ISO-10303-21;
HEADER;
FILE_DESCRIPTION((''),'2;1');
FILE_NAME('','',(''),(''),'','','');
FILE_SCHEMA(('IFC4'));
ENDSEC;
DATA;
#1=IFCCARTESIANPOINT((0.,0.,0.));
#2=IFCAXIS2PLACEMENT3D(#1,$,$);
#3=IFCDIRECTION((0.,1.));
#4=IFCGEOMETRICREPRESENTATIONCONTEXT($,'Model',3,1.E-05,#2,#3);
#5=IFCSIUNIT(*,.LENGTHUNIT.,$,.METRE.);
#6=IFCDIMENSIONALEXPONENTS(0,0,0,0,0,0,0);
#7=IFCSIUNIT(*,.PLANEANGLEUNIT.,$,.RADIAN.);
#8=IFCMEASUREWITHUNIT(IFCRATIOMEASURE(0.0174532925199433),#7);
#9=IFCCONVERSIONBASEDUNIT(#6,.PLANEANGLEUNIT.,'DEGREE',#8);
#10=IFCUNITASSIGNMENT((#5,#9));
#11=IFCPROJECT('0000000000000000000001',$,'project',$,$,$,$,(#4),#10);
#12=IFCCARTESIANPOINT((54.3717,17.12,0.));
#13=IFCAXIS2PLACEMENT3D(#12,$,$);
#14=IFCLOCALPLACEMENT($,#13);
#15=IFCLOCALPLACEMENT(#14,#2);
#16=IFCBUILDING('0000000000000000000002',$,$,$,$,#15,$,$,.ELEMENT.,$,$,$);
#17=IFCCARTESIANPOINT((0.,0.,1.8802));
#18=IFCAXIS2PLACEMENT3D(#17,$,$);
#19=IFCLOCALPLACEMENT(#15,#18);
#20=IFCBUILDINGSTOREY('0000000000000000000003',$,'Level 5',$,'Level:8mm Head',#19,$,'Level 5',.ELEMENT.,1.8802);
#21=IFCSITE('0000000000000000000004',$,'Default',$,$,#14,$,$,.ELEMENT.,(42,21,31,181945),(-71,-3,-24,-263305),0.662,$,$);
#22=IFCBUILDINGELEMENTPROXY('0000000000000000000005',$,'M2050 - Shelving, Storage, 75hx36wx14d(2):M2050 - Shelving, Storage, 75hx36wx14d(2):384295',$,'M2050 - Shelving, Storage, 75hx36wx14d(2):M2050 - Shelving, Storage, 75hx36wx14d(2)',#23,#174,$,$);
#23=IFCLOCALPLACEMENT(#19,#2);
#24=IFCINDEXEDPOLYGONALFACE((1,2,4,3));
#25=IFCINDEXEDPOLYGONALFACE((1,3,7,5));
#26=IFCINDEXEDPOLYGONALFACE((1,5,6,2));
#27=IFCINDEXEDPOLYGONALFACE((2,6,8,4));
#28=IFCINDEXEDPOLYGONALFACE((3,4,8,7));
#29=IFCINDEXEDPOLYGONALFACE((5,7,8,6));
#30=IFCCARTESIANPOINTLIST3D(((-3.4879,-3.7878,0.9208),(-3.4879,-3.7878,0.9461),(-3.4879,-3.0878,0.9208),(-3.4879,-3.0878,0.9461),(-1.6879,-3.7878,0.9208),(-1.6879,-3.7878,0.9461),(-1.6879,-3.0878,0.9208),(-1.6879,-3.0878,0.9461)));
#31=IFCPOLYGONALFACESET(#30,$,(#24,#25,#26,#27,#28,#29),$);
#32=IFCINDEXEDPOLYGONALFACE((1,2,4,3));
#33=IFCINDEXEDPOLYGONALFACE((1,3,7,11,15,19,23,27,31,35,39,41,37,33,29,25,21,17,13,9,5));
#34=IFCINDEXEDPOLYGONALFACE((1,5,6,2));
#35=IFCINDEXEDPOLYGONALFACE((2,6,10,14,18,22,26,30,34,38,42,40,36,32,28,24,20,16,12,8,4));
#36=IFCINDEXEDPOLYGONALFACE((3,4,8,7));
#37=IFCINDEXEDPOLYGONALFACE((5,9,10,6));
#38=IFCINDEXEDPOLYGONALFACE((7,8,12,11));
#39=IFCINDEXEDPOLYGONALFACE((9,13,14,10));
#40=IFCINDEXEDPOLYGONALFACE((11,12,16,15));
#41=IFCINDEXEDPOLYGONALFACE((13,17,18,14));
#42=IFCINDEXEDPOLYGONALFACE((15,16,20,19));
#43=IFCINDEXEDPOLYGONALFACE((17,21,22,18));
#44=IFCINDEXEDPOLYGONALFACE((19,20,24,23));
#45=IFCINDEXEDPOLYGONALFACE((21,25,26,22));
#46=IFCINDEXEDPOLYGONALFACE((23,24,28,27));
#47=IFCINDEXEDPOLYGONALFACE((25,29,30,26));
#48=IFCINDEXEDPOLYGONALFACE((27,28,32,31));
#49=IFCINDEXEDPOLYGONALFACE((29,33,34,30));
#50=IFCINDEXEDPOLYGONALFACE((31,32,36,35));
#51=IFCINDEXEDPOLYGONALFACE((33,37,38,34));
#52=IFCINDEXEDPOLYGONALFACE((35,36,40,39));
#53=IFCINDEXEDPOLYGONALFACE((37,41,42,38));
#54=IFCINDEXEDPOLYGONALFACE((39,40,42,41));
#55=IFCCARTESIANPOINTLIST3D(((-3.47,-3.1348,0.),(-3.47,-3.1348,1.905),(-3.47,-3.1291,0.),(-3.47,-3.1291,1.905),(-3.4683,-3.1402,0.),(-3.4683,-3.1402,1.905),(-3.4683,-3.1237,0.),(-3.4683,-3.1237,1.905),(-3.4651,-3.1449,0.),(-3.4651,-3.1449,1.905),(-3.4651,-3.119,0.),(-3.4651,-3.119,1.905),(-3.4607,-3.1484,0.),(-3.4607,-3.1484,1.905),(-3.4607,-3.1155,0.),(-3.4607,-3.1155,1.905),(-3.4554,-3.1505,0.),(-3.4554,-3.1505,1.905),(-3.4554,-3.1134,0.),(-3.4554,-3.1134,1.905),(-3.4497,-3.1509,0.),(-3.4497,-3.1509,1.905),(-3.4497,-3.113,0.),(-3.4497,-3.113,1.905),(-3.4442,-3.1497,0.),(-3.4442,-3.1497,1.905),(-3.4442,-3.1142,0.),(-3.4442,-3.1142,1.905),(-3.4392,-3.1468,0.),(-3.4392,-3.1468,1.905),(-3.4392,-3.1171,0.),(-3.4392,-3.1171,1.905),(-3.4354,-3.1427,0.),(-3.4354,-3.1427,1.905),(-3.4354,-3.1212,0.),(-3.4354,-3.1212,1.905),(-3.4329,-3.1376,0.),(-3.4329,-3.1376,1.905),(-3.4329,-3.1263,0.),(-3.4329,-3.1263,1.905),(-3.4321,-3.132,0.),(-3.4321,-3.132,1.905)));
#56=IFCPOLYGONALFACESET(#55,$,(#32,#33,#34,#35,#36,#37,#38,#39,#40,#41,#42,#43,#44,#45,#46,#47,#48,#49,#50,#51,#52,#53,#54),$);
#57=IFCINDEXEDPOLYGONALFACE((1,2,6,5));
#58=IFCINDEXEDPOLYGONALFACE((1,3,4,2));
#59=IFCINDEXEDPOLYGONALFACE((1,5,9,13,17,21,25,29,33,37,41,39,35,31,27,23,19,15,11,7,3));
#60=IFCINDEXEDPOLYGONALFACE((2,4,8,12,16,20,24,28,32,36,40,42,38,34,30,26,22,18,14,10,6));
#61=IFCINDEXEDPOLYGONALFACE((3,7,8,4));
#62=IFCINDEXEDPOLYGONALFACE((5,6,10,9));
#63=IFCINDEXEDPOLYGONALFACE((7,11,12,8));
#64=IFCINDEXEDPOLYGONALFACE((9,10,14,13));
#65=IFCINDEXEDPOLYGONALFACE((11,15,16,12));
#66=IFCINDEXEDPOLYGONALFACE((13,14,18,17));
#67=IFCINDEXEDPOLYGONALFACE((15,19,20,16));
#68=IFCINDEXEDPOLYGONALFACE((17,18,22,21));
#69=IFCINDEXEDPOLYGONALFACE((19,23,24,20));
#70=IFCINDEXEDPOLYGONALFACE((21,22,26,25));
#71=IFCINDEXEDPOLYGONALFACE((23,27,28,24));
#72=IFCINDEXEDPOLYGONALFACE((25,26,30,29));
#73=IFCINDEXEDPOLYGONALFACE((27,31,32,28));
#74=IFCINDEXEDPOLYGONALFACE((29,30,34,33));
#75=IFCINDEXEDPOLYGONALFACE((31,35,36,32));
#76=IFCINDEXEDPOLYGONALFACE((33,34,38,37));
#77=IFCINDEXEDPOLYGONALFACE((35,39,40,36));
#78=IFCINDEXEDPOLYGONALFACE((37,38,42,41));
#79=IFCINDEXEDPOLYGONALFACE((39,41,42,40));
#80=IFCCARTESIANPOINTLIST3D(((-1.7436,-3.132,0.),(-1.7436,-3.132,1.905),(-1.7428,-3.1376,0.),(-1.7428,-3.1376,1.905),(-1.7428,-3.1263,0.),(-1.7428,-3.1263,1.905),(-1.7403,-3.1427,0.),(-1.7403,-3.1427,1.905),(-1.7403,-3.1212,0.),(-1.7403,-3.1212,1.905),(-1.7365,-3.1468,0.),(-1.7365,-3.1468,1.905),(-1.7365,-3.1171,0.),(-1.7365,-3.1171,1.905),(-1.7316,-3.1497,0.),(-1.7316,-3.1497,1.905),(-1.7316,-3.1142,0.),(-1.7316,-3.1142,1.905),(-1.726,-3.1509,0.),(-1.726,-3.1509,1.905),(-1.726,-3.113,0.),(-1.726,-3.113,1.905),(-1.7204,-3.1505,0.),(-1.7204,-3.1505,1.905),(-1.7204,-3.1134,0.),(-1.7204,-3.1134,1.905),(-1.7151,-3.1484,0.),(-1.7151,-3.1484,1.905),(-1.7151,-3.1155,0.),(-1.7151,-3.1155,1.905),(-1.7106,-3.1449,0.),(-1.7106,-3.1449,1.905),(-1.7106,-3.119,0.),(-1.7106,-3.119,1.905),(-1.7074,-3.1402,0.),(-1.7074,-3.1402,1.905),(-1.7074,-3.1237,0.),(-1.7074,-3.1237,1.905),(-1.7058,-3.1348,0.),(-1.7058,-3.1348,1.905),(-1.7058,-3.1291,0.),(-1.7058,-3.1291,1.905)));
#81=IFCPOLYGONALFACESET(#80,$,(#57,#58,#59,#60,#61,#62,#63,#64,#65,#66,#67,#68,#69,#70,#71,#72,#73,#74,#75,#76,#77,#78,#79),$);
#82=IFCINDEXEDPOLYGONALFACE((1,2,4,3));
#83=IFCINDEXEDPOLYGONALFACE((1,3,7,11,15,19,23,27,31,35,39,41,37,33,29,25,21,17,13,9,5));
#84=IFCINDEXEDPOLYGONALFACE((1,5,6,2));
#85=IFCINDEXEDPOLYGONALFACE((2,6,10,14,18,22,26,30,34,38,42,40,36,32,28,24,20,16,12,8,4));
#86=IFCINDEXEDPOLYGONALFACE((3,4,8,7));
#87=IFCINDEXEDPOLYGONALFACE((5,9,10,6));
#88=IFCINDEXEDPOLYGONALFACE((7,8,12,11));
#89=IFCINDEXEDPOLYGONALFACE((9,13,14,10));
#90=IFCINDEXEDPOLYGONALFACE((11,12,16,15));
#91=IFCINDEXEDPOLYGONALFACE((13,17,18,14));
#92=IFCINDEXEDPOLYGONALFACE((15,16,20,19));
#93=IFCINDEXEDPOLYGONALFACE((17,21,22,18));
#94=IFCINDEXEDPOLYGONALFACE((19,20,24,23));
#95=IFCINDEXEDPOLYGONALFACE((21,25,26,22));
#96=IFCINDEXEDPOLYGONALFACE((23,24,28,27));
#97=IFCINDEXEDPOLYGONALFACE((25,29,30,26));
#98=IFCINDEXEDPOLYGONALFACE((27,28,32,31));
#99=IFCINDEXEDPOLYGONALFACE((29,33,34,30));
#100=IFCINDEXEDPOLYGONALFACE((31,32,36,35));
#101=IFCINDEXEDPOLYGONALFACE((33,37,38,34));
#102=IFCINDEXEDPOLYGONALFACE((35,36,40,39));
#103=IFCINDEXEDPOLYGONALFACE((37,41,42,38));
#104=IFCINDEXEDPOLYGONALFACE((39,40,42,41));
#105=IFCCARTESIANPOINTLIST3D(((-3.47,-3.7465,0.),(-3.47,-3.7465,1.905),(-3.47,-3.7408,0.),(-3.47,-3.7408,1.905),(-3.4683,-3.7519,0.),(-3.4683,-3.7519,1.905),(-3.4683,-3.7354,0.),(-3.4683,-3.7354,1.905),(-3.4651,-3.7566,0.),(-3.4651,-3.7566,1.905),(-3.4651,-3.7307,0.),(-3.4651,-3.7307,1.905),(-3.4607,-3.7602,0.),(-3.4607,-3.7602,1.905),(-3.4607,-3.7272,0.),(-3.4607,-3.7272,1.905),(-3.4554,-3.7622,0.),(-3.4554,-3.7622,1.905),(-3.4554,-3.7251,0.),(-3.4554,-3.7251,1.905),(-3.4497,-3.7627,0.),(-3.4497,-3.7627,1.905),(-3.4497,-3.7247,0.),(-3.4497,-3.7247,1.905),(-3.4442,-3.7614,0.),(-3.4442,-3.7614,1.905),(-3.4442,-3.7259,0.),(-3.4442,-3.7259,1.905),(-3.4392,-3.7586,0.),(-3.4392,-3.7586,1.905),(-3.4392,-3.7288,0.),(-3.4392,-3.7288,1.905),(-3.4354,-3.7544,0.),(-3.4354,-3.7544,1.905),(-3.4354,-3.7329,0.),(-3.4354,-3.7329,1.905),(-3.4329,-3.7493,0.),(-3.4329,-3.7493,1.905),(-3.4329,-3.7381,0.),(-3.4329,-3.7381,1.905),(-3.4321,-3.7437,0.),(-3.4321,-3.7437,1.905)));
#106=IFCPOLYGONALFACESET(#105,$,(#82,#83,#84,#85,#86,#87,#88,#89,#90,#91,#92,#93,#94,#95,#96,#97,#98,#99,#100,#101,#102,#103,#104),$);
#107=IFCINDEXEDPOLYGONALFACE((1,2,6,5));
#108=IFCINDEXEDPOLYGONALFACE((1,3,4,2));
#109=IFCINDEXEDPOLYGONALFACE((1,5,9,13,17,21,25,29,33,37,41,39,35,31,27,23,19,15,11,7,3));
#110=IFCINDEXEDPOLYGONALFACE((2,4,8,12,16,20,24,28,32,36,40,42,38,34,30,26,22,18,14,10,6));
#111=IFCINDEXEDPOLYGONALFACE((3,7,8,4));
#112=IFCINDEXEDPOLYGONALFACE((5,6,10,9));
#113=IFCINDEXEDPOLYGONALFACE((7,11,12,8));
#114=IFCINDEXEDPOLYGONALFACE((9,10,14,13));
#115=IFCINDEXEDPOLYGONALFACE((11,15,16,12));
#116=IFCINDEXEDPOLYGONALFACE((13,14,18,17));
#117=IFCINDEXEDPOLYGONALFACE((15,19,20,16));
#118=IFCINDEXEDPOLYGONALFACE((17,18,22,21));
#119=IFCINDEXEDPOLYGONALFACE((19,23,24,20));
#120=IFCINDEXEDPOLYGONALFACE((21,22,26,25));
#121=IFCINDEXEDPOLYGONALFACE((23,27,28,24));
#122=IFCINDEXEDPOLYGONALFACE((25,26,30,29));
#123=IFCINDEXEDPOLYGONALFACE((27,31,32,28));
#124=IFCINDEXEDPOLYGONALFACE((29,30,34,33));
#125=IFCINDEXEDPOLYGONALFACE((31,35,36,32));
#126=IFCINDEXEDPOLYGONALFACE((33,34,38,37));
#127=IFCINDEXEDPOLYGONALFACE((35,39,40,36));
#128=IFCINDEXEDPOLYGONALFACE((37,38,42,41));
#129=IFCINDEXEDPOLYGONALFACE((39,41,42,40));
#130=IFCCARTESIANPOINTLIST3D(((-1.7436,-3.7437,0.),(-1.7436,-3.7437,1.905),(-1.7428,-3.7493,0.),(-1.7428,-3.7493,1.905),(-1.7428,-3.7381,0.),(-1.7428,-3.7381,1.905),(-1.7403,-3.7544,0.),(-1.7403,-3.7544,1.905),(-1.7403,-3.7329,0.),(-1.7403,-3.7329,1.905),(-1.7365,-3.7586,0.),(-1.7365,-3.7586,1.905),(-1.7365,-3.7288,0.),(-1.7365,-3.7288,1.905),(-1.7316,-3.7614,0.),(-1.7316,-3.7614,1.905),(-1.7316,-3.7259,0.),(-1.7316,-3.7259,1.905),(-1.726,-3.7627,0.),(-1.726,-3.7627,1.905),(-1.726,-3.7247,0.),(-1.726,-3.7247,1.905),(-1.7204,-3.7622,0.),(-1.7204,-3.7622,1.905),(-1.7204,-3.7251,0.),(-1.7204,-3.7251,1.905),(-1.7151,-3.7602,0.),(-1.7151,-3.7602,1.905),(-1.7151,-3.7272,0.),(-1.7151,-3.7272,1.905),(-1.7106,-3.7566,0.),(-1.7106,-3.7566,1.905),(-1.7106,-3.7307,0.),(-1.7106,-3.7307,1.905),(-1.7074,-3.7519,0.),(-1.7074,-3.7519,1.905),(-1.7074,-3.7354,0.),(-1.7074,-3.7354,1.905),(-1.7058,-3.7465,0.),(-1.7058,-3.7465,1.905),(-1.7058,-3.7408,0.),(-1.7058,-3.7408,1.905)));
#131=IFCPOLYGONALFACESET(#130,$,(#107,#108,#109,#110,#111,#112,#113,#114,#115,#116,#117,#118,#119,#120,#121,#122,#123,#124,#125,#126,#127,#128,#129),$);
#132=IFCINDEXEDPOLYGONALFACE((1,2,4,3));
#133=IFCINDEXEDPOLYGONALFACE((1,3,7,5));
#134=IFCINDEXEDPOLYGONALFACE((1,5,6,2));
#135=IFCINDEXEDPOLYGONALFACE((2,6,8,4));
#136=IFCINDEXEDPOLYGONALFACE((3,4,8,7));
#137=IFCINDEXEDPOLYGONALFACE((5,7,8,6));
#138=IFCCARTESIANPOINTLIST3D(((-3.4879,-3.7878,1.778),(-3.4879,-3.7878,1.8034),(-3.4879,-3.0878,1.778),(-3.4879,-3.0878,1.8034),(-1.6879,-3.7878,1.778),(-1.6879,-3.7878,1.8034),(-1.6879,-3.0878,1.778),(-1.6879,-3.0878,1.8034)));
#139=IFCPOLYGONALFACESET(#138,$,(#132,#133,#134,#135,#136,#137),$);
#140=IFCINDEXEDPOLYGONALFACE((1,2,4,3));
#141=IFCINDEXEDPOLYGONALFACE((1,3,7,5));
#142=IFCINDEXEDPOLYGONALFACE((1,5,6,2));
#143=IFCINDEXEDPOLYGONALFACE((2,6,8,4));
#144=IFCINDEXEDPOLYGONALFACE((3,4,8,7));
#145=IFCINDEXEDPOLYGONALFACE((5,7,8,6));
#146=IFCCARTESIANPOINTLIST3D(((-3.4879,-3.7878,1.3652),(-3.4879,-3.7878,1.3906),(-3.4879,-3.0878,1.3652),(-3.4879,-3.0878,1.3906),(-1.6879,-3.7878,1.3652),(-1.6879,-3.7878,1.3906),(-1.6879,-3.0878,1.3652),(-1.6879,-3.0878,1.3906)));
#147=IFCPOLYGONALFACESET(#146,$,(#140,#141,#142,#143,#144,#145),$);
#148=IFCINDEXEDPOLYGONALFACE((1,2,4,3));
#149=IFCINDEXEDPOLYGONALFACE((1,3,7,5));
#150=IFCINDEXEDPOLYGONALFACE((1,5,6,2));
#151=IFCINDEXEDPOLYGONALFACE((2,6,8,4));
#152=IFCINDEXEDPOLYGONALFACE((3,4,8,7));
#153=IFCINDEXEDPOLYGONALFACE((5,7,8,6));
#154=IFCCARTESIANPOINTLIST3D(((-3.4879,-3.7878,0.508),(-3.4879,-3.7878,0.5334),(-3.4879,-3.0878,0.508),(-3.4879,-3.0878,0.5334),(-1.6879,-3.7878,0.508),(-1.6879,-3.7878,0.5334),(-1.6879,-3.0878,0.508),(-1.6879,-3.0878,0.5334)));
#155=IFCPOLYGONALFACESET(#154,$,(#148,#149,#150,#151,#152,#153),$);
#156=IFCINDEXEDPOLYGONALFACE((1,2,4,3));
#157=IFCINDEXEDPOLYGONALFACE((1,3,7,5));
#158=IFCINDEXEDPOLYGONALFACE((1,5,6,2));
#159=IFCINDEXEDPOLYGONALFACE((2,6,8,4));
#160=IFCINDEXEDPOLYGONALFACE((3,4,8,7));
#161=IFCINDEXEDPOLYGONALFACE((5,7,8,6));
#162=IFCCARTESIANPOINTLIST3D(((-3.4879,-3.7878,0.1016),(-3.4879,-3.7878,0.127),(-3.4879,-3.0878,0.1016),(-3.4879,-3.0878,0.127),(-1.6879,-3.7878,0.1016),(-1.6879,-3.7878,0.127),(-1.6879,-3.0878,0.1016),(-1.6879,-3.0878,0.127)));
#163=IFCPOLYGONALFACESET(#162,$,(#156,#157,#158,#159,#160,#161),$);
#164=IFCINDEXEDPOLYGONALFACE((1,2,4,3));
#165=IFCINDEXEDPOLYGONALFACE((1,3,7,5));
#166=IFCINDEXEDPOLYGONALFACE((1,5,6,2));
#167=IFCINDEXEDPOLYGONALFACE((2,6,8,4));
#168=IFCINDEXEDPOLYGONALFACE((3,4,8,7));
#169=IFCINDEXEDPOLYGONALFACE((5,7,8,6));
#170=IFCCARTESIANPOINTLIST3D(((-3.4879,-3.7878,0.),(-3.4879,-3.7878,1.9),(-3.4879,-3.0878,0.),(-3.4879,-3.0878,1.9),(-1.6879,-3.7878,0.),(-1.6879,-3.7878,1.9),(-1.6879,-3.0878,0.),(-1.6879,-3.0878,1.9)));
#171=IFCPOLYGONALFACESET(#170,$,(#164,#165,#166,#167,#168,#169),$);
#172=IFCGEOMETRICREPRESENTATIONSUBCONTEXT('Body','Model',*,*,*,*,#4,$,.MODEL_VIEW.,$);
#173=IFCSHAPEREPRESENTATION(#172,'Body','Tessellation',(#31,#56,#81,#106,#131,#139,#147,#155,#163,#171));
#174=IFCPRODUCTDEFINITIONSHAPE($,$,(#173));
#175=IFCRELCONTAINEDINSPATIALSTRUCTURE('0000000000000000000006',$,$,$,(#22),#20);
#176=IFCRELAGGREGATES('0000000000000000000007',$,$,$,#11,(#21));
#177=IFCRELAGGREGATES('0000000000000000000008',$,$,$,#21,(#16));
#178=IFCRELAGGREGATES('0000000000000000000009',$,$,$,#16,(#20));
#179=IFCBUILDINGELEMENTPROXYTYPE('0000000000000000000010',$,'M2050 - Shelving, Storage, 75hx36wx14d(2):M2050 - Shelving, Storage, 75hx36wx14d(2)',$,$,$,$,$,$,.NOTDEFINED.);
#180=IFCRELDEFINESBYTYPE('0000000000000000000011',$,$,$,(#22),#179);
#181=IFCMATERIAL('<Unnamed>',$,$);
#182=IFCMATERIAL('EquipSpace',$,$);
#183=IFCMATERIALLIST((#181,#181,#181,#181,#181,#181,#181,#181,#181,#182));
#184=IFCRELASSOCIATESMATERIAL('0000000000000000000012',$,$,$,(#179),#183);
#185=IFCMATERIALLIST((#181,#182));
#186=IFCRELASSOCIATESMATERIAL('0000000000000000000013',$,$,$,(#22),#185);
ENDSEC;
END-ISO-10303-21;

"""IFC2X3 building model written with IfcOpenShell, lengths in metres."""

from ifc_helpers import new_model, entity, si_unit, converted_unit, direction, frame, frame_2d, origin, origin_2d_with_axis, place, context, subcontext, project, spatial, rectangle, circle, extrude, source, transform, mapped, material, material_list, type_object, type_shapes, element, save


model = new_model("IFC2X3")

# Units and contexts
model_context = context("Model", 3, precision=1e-05, world=origin(), true_north=direction((0.0, 1.0)))
body_context = subcontext(model_context, "Body", "Model", "MODEL_VIEW")
ifc_project = project(units=[si_unit("LENGTHUNIT", "METRE"), converted_unit("PLANEANGLEUNIT", "DEGREE", entity("IfcRatioMeasure", 0.0174532925199433), si_unit("PLANEANGLEUNIT", "RADIAN"), dimensions=[0, 0, 0, 0, 0, 0, 0])], contexts=[model_context])

# Site, building, storey
site_placement = place(None, frame((54.3717, 17.12, 0.0)))
site = spatial("IfcSite", under=ifc_project, at=site_placement, Name="Default", CompositionType="ELEMENT", RefLatitude=(42, 21, 31, 181945), RefLongitude=(-71, -3, -24, -263305), RefElevation=0.662)
building_placement = place(site_placement, origin())
building = spatial("IfcBuilding", under=site, at=building_placement, CompositionType="ELEMENT")
storey_placement = place(building_placement, frame((0.0, 0.0, 1.8802)))
storey = spatial("IfcBuildingStorey", under=building, at=storey_placement, Name="Level 5", ObjectType="Level:8mm Head", LongName="Level 5", CompositionType="ELEMENT", Elevation=1.8802)

# Building element proxy
ifc_material_1 = material(Name="<Unnamed>")
ifc_material_2 = material(Name="EquipSpace")
ifc_material_list_1 = material_list([ifc_material_1, ifc_material_1, ifc_material_1, ifc_material_1, ifc_material_1, ifc_material_1, ifc_material_1, ifc_material_1, ifc_material_1, ifc_material_2])
building_element_proxy_type = type_object("IfcBuildingElementProxyType", Name="M2050 - Shelving, Storage, 75hx36wx14d(2):M2050 - Shelving, Storage, 75hx36wx14d(2)", PredefinedType="NOTDEFINED", material=ifc_material_list_1)
shared_shape = source(origin(), body_context, "Body", "SweptSolid", [
    extrude(rectangle(XDim=1.8, YDim=0.7, at=origin_2d_with_axis()), frame((0.0, 0.0, 0.9207), z_axis=(0.0, 0.0, 1.0), x_axis=(-1.0, 0.0, 0.0)), (0.0, 0.0, 1.0), 0.0254),
    extrude(circle(Radius=0.0191, at=origin_2d_with_axis()), frame((0.8633, -0.3059, 0.0), z_axis=(0.0, 0.0, 1.0), x_axis=(-1.0, 0.0, 0.0)), (0.0, 0.0, 1.0), 1.905),
    extrude(circle(Radius=0.0191, at=origin_2d_with_axis()), frame((-0.8633, -0.3059, 0.0)), (0.0, 0.0, 1.0), 1.905),
    extrude(circle(Radius=0.0191, at=origin_2d_with_axis()), frame((0.8633, 0.3059, 0.0), z_axis=(0.0, 0.0, 1.0), x_axis=(-1.0, 0.0, 0.0)), (0.0, 0.0, 1.0), 1.905),
    extrude(circle(Radius=0.0191, at=origin_2d_with_axis()), frame((-0.8633, 0.3059, 0.0)), (0.0, 0.0, 1.0), 1.905),
    extrude(rectangle(XDim=1.8, YDim=0.7, at=origin_2d_with_axis()), frame((0.0, 0.0, 1.778), z_axis=(0.0, 0.0, 1.0), x_axis=(-1.0, 0.0, 0.0)), (0.0, 0.0, 1.0), 0.0254),
    extrude(rectangle(XDim=1.8, YDim=0.7, at=origin_2d_with_axis()), frame((0.0, 0.0, 1.3653), z_axis=(0.0, 0.0, 1.0), x_axis=(-1.0, 0.0, 0.0)), (0.0, 0.0, 1.0), 0.0254),
    extrude(rectangle(XDim=1.8, YDim=0.7, at=origin_2d_with_axis()), frame((0.0, 0.0, 0.508), z_axis=(0.0, 0.0, 1.0), x_axis=(-1.0, 0.0, 0.0)), (0.0, 0.0, 1.0), 0.0254),
    extrude(rectangle(XDim=1.8, YDim=0.7, at=origin_2d_with_axis()), frame((0.0, 0.0, 0.1016), z_axis=(0.0, 0.0, 1.0), x_axis=(-1.0, 0.0, 0.0)), (0.0, 0.0, 1.0), 0.0254),
    extrude(rectangle(XDim=0.7, YDim=1.8, at=frame_2d((0.0, 0.18), x_axis=(1.0, 0.0))), frame((-0.18, 0.0, 0.0), z_axis=(0.0, 0.0, 1.0), x_axis=(0.0, -1.0, 0.0)), (0.0, 0.0, 1.0), 1.9),
])
type_shapes(building_element_proxy_type, [shared_shape])
ifc_material_list_2 = material_list([ifc_material_1, ifc_material_2])
proxy_1_placement = place(storey_placement, frame((-2.5879, -3.4378, 0.0), z_axis=(0.0, 0.0, 1.0), x_axis=(-1.0, 0.0, 0.0)))
element("IfcBuildingElementProxy", 1, at=proxy_1_placement, inside=storey, type_object=building_element_proxy_type, material=ifc_material_list_2, Name="M2050 - Shelving, Storage, 75hx36wx14d(2):M2050 - Shelving, Storage, 75hx36wx14d(2):384295", ObjectType="M2050 - Shelving, Storage, 75hx36wx14d(2):M2050 - Shelving, Storage, 75hx36wx14d(2)", context=body_context, shape_type="MappedRepresentation", body=[
    mapped(shared_shape, transform((0.0, 0.0, 0.0), scale=1.0)),
])

save(model, "model.ifc")
